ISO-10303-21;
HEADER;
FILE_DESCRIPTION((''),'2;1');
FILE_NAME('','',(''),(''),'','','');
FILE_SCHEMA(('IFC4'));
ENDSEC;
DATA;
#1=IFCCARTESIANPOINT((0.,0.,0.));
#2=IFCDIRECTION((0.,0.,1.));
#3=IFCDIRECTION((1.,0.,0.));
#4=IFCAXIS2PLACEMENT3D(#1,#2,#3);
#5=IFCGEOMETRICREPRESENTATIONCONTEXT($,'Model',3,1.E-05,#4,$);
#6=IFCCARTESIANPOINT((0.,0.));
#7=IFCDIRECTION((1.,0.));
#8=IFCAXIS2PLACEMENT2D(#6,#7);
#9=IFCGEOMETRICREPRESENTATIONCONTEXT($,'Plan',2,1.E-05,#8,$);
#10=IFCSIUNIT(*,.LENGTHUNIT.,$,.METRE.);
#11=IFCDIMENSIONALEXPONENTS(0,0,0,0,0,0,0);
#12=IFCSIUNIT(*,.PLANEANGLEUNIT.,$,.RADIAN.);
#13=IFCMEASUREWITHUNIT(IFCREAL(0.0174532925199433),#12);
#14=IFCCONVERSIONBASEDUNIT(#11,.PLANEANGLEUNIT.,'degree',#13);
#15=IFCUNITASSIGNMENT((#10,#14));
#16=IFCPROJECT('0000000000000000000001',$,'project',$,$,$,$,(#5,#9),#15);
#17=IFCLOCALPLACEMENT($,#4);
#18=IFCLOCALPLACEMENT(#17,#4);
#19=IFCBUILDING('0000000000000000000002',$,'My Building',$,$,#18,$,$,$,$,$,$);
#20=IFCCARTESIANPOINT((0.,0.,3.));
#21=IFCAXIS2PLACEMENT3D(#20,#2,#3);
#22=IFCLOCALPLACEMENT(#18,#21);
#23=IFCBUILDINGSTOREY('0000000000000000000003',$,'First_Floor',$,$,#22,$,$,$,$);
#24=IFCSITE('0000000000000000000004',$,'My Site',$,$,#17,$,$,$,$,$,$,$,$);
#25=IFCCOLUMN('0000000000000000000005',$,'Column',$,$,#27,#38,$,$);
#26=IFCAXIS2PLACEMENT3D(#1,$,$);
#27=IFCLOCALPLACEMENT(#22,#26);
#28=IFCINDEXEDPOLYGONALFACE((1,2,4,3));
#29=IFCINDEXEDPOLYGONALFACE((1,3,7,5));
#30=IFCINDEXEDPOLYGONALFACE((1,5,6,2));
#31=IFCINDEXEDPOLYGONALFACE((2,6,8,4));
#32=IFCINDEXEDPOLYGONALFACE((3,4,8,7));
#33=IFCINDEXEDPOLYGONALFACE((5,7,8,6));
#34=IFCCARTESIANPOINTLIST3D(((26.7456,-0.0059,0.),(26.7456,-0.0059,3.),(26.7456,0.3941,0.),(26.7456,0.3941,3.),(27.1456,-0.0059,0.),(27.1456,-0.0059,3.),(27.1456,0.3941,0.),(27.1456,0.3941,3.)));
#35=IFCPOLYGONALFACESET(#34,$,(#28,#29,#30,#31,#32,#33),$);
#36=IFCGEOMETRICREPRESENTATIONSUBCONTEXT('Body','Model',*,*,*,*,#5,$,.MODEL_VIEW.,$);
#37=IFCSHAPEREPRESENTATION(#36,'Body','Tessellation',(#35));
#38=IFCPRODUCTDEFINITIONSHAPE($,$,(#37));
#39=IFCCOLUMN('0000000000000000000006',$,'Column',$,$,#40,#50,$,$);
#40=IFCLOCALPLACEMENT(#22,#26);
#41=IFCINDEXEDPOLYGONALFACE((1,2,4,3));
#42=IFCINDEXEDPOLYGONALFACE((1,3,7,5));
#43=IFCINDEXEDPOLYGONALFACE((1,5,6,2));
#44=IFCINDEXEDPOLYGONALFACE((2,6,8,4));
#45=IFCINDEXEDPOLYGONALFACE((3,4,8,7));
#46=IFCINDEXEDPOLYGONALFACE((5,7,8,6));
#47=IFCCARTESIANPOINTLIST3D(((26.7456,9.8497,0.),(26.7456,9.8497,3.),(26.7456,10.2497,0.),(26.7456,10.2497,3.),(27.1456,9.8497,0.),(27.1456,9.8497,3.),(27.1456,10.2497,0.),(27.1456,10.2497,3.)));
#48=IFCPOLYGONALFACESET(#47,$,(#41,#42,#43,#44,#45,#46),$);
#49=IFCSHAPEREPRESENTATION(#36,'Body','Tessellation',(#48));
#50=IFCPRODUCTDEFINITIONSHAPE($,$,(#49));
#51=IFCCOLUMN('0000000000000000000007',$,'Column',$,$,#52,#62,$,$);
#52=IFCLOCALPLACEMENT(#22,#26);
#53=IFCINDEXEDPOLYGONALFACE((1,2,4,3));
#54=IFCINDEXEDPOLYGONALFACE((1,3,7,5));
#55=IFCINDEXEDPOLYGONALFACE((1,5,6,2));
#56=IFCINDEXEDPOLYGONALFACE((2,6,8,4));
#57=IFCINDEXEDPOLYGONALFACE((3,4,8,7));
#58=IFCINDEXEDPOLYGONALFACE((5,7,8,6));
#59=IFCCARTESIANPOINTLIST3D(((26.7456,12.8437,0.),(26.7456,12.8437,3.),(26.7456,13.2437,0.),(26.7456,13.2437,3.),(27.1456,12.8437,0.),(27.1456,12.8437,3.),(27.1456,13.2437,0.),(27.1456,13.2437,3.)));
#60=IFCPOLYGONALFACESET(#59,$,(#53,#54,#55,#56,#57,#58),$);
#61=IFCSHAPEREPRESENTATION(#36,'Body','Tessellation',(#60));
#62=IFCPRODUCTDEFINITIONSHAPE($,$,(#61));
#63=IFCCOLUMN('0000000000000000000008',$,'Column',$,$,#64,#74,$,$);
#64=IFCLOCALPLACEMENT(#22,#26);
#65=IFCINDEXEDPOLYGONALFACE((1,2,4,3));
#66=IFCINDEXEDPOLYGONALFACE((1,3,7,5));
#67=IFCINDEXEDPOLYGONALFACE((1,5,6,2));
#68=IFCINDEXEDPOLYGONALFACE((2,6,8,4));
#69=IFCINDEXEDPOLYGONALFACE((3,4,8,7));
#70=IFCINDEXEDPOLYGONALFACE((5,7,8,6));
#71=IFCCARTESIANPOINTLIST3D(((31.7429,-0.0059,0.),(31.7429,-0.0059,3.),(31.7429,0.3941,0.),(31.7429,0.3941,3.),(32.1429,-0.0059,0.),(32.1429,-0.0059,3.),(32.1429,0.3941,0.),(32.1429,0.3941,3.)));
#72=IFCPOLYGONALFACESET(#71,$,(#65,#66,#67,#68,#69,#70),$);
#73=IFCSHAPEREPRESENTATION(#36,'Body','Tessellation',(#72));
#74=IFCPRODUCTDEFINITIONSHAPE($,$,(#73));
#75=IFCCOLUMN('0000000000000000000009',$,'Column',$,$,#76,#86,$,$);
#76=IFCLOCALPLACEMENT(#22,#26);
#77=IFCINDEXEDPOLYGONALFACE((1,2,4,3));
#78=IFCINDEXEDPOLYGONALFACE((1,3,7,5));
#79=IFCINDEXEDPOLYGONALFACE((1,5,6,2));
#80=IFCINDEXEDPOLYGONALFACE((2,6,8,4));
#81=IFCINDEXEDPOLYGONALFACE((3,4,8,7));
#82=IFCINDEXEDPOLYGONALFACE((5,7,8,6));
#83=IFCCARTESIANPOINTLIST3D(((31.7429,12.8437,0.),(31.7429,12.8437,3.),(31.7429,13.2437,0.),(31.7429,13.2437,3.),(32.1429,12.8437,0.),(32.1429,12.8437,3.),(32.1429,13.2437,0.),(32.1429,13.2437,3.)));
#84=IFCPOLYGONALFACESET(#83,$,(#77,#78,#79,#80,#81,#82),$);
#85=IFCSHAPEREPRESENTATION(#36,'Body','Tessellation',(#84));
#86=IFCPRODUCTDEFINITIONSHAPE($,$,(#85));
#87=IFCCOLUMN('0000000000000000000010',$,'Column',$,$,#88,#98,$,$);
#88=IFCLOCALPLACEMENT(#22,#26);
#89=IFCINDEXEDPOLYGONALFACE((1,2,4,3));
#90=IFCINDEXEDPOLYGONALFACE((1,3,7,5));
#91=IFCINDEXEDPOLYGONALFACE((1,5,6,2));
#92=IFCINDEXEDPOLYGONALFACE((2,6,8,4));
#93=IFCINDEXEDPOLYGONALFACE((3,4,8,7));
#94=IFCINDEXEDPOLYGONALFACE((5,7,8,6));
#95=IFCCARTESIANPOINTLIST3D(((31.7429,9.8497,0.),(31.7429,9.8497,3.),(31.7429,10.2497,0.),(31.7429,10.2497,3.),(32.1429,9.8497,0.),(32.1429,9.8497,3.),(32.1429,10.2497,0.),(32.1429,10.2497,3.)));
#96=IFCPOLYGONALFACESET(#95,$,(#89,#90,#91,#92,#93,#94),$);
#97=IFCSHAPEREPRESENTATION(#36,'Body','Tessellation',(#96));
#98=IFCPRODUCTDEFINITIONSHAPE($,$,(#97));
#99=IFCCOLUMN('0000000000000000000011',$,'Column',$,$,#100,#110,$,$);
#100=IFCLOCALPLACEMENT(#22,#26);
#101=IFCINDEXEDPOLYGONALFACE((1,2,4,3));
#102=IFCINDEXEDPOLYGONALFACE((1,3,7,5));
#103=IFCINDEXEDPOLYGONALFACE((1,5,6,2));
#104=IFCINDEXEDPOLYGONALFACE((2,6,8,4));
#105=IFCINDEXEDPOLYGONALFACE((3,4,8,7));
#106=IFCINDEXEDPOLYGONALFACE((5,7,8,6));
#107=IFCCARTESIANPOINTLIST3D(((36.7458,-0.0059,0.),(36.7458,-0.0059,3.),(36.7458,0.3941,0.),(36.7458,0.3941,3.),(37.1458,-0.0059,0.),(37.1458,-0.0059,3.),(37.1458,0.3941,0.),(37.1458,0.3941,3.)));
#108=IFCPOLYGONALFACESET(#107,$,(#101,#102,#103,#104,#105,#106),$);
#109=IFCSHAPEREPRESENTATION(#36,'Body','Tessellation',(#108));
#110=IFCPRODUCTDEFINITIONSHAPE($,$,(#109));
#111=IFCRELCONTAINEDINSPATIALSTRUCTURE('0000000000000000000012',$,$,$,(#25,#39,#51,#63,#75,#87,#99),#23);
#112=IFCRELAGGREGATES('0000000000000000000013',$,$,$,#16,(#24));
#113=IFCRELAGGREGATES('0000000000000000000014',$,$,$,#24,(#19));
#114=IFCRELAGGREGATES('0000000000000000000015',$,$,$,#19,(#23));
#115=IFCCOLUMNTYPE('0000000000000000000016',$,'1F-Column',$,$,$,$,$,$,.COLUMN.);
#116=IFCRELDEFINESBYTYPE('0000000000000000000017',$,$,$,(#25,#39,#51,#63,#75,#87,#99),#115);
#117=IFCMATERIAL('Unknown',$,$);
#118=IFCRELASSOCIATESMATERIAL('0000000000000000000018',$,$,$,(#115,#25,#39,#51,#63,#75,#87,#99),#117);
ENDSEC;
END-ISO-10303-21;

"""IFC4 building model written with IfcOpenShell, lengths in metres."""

from ifc_helpers import new_model, entity, si_unit, converted_unit, frame, origin_with_axes, origin_2d_with_axis, place, context, subcontext, project, spatial, rectangle, extrude, material, material_profile, profile_set, profile_usage, type_object, element, save


model = new_model("IFC4")

# Units and contexts
model_context = context("Model", 3, precision=1e-05, world=origin_with_axes())
plan_context = context("Plan", 2, precision=1e-05, world=origin_2d_with_axis())
body_context_1 = subcontext(model_context, "Body", "Model", "MODEL_VIEW")
ifc_project = project(units=[si_unit("LENGTHUNIT", "METRE"), converted_unit("PLANEANGLEUNIT", "degree", entity("IfcReal", 0.0174532925199433), si_unit("PLANEANGLEUNIT", "RADIAN"), dimensions=[0, 0, 0, 0, 0, 0, 0])], contexts=[model_context, plan_context])

# Site, building, storey
site_placement = place(None, origin_with_axes())
site = spatial("IfcSite", under=ifc_project, at=site_placement, Name="My Site")
building_placement = place(site_placement, origin_with_axes())
building = spatial("IfcBuilding", under=site, at=building_placement, Name="My Building")
storey_placement = place(building_placement, frame((0.0, 0.0, 3.0), z_axis=(0.0, 0.0, 1.0), x_axis=(1.0, 0.0, 0.0)))
storey = spatial("IfcBuildingStorey", under=building, at=storey_placement, Name="First_Floor")

# Columns
ifc_material = material(Name="Unknown")
ifc_material_profile = material_profile(ifc_material, rectangle(XDim=0.4, YDim=0.4))
ifc_profile_set = profile_set([ifc_material_profile])
ifc_profile_usage_1 = profile_usage(ifc_profile_set, cardinal=5)
column_type = type_object("IfcColumnType", Name="1F-Column", PredefinedType="COLUMN", material=ifc_profile_set)
column_1_placement = place(storey_placement, frame((26.9456, 0.1941, 0.0), z_axis=(0.0, 0.0, 1.0), x_axis=(1.0, 0.0, 0.0)))
element("IfcColumn", 1, at=column_1_placement, inside=storey, type_object=column_type, material=ifc_profile_usage_1, Name="Column", context=body_context_1, shape_type="SweptSolid", body=[
    extrude(rectangle(XDim=0.4, YDim=0.4), origin_with_axes(), (0.0, 0.0, 1.0), 3.0),
])
ifc_profile_usage_2 = profile_usage(ifc_profile_set, cardinal=5)
column_2_placement = place(storey_placement, frame((26.9456, 10.0497, 0.0), z_axis=(0.0, 0.0, 1.0), x_axis=(1.0, 0.0, 0.0)))
element("IfcColumn", 2, at=column_2_placement, inside=storey, type_object=column_type, material=ifc_profile_usage_2, Name="Column", context=body_context_1, shape_type="SweptSolid", body=[
    extrude(rectangle(XDim=0.4, YDim=0.4), origin_with_axes(), (0.0, 0.0, 1.0), 3.0),
])
ifc_profile_usage_3 = profile_usage(ifc_profile_set, cardinal=5)
column_3_placement = place(storey_placement, frame((26.9456, 13.0437, 0.0), z_axis=(0.0, 0.0, 1.0), x_axis=(1.0, 0.0, 0.0)))
element("IfcColumn", 3, at=column_3_placement, inside=storey, type_object=column_type, material=ifc_profile_usage_3, Name="Column", context=body_context_1, shape_type="SweptSolid", body=[
    extrude(rectangle(XDim=0.4, YDim=0.4), origin_with_axes(), (0.0, 0.0, 1.0), 3.0),
])
ifc_profile_usage_4 = profile_usage(ifc_profile_set, cardinal=5)
column_4_placement = place(storey_placement, frame((31.9429, 0.1941, 0.0), z_axis=(0.0, 0.0, 1.0), x_axis=(1.0, 0.0, 0.0)))
element("IfcColumn", 4, at=column_4_placement, inside=storey, type_object=column_type, material=ifc_profile_usage_4, Name="Column", context=body_context_1, shape_type="SweptSolid", body=[
    extrude(rectangle(XDim=0.4, YDim=0.4), origin_with_axes(), (0.0, 0.0, 1.0), 3.0),
])
ifc_profile_usage_5 = profile_usage(ifc_profile_set, cardinal=5)
column_5_placement = place(storey_placement, frame((31.9429, 13.0437, 0.0), z_axis=(0.0, 0.0, 1.0), x_axis=(1.0, 0.0, 0.0)))
element("IfcColumn", 5, at=column_5_placement, inside=storey, type_object=column_type, material=ifc_profile_usage_5, Name="Column", context=body_context_1, shape_type="SweptSolid", body=[
    extrude(rectangle(XDim=0.4, YDim=0.4), origin_with_axes(), (0.0, 0.0, 1.0), 3.0),
])
ifc_profile_usage_6 = profile_usage(ifc_profile_set, cardinal=5)
column_6_placement = place(storey_placement, frame((31.9429, 10.0497, 0.0), z_axis=(0.0, 0.0, 1.0), x_axis=(1.0, 0.0, 0.0)))
element("IfcColumn", 6, at=column_6_placement, inside=storey, type_object=column_type, material=ifc_profile_usage_6, Name="Column", context=body_context_1, shape_type="SweptSolid", body=[
    extrude(rectangle(XDim=0.4, YDim=0.4), origin_with_axes(), (0.0, 0.0, 1.0), 3.0),
])
ifc_profile_usage_7 = profile_usage(ifc_profile_set, cardinal=5)
column_7_placement = place(storey_placement, frame((36.9458, 0.1941, 0.0), z_axis=(0.0, 0.0, 1.0), x_axis=(1.0, 0.0, 0.0)))
element("IfcColumn", 7, at=column_7_placement, inside=storey, type_object=column_type, material=ifc_profile_usage_7, Name="Column", context=body_context_1, shape_type="SweptSolid", body=[
    extrude(rectangle(XDim=0.4, YDim=0.4), origin_with_axes(), (0.0, 0.0, 1.0), 3.0),
])

save(model, "model.ifc")
